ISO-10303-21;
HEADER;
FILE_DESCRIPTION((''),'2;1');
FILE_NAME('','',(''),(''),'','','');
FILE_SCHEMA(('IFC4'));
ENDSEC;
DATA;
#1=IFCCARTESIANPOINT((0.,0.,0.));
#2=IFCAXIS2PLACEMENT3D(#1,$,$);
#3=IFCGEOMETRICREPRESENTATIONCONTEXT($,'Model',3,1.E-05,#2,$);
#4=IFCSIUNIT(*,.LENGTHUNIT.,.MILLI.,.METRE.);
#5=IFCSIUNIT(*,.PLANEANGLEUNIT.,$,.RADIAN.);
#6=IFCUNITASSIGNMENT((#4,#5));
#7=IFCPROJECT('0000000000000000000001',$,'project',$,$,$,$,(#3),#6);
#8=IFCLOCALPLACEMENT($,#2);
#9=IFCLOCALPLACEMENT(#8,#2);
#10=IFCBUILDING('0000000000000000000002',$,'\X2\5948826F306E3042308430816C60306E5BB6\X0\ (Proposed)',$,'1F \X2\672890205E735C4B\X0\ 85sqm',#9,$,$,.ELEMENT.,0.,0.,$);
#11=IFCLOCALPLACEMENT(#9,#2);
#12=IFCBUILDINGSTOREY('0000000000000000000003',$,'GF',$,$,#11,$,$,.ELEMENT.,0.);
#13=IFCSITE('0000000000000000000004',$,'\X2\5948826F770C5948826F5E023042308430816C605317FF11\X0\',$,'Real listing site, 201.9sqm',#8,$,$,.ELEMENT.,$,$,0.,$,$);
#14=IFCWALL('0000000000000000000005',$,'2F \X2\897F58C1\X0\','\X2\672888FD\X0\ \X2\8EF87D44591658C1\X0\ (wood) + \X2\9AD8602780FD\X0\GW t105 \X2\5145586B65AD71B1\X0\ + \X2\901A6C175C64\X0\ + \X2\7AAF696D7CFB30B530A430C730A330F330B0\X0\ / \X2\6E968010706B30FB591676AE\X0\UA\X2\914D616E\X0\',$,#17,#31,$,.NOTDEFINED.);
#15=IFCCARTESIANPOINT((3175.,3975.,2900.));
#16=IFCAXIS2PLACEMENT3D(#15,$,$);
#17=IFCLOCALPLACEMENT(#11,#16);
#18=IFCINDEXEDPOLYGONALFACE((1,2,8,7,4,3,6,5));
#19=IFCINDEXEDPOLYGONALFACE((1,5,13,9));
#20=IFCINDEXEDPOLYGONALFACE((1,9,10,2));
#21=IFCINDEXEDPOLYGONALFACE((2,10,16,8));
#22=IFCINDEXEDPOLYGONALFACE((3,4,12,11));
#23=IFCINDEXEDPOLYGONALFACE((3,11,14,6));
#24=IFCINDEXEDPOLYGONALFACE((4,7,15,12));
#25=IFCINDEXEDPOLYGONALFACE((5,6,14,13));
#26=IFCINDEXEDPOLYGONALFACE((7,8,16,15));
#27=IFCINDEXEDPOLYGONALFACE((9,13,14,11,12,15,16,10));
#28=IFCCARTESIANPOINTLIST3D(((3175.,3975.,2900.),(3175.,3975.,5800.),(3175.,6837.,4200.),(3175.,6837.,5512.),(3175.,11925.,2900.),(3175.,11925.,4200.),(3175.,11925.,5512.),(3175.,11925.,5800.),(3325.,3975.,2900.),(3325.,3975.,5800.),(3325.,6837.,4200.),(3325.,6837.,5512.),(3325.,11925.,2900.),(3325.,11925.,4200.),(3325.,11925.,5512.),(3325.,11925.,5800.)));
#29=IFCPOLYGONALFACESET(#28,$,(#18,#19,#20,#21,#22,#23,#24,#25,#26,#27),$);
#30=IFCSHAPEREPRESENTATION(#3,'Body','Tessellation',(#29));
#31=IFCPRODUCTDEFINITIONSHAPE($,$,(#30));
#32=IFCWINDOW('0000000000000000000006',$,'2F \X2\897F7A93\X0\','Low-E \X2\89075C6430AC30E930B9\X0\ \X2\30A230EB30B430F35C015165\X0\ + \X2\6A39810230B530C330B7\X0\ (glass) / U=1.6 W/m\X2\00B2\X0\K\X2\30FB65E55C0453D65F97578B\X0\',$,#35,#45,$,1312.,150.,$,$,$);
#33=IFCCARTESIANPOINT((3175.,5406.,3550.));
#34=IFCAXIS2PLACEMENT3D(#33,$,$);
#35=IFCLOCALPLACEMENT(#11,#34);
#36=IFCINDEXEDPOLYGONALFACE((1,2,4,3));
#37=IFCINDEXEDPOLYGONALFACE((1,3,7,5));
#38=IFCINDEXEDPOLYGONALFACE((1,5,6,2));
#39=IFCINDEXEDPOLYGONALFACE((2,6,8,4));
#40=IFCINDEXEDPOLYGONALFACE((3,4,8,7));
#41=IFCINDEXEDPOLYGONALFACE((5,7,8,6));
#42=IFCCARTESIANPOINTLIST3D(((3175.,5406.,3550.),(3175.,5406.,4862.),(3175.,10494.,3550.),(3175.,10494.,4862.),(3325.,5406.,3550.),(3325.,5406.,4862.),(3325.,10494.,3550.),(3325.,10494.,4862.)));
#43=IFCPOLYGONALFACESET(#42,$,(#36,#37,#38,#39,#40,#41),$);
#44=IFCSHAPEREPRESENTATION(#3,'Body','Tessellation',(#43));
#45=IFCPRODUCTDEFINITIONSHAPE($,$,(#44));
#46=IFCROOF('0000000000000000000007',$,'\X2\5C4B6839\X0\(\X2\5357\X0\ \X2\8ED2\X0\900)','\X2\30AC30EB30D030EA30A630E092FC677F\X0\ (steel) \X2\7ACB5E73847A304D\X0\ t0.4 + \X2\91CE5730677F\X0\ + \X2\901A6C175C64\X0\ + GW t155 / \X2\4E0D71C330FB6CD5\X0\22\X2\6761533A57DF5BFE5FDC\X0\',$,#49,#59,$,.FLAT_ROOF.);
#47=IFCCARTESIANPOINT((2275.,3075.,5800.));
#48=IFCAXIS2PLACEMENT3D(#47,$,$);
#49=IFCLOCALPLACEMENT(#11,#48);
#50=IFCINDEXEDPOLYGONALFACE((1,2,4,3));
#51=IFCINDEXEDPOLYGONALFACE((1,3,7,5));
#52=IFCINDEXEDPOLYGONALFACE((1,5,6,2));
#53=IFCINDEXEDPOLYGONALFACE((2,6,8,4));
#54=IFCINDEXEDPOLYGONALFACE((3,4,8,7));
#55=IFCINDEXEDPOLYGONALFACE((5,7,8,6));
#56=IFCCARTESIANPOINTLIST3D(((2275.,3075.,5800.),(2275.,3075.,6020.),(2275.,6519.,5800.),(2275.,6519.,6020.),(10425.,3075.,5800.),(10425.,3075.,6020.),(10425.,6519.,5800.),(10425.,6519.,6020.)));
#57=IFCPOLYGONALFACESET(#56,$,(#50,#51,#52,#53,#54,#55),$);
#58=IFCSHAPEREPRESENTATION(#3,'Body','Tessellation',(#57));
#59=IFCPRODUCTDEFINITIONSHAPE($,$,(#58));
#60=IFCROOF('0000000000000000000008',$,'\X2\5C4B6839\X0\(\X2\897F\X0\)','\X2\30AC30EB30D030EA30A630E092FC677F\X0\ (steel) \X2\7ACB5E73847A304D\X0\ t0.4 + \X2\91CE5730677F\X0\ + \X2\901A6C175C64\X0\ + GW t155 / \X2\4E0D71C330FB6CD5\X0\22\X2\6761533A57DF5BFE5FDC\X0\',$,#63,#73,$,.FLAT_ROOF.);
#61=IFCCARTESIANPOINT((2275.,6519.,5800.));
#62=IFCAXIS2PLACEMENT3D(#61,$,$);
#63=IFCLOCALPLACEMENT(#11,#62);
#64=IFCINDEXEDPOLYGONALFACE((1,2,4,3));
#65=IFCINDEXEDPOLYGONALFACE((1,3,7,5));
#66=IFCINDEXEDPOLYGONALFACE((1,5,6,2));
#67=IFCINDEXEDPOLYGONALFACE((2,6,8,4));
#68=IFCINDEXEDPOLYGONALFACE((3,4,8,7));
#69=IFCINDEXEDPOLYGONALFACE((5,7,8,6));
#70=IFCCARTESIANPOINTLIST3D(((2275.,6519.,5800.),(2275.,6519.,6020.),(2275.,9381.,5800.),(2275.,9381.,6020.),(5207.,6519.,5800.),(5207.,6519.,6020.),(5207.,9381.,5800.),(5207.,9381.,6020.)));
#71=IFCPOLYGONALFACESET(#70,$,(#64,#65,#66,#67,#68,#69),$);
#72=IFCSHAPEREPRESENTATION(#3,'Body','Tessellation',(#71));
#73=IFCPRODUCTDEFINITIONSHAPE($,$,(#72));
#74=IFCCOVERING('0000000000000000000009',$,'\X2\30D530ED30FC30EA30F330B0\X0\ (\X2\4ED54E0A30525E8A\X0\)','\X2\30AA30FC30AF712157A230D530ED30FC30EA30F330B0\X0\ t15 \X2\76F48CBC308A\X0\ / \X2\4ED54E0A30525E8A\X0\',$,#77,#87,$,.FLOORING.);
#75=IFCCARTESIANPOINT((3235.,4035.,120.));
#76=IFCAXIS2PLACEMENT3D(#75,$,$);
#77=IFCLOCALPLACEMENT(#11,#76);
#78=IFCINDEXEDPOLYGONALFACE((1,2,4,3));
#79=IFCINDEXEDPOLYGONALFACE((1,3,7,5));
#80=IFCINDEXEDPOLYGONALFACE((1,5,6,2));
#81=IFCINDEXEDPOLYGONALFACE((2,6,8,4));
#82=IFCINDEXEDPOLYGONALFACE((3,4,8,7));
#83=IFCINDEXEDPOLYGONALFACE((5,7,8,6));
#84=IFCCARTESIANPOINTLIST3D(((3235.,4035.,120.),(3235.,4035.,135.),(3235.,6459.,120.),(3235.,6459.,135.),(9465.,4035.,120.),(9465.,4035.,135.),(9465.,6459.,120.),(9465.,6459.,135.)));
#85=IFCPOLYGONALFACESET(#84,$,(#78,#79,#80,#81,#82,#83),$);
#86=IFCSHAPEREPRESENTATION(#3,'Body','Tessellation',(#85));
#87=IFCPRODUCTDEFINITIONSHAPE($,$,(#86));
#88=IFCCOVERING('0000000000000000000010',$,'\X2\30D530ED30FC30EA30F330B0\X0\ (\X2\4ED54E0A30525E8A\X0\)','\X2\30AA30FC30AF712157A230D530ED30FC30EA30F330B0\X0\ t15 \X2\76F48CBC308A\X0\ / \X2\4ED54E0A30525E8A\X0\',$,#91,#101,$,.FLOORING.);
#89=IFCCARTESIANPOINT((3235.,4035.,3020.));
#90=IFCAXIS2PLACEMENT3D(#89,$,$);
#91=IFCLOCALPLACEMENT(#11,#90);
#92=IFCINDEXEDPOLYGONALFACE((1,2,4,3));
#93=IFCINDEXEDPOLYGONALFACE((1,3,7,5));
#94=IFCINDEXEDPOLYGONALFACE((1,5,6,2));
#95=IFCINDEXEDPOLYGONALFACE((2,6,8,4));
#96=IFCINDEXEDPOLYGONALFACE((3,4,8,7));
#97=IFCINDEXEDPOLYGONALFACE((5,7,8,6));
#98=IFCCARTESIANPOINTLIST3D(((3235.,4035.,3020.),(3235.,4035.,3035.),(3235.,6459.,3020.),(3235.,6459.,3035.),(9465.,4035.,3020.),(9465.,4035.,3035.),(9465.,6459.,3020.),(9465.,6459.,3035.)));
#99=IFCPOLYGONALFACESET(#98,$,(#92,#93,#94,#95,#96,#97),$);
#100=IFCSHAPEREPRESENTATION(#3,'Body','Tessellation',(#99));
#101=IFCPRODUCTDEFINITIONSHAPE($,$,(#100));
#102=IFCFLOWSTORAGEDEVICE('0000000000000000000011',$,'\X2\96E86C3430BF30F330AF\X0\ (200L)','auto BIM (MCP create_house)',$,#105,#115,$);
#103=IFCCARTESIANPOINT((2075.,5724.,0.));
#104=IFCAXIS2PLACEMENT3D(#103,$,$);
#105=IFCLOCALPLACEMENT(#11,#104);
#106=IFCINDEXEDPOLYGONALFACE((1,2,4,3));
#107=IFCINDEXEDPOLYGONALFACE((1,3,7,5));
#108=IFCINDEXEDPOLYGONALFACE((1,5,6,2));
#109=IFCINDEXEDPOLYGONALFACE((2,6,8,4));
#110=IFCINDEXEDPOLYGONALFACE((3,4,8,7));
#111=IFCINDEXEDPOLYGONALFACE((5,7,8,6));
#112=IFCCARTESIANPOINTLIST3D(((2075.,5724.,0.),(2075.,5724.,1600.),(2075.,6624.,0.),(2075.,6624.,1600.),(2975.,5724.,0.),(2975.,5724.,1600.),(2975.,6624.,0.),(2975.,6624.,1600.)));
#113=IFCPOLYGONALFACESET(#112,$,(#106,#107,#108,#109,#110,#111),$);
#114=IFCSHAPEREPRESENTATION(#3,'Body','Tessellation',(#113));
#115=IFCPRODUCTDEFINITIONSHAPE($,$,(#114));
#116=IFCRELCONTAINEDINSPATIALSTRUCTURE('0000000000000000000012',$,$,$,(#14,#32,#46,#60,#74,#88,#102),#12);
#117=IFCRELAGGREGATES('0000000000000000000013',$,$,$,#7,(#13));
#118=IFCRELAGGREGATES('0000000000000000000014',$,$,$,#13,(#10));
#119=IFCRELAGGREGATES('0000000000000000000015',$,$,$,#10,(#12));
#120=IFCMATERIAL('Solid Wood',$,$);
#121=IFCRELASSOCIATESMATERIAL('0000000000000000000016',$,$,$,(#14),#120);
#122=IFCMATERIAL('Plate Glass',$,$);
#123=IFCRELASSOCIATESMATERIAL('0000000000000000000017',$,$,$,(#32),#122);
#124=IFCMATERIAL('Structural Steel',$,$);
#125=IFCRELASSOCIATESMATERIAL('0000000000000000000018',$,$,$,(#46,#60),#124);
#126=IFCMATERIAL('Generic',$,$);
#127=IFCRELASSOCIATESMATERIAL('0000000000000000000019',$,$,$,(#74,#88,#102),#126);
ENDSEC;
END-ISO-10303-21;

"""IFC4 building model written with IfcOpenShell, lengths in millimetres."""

from ifc_helpers import new_model, si_unit, frame, frame_2d, origin, place, context, project, spatial, rectangle, extrude, material, element, fill, save


model = new_model("IFC4")

# Units and contexts
model_context = context("Model", 3, precision=1e-05, world=origin())
ifc_project = project(units=[si_unit("LENGTHUNIT", "METRE", prefix="MILLI"), si_unit("PLANEANGLEUNIT", "RADIAN")], contexts=[model_context])

# Site, building, storey
site_placement = place(None, origin())
site = spatial("IfcSite", under=ifc_project, at=site_placement, Name="奈良県奈良市あやめ池北１", ObjectType="Real listing site, 201.9sqm", CompositionType="ELEMENT", RefElevation=0.0)
building_placement = place(site_placement, origin())
building = spatial("IfcBuilding", under=site, at=building_placement, Name="奈良のあやめ池の家 (Proposed)", ObjectType="1F 木造平屋 85sqm", CompositionType="ELEMENT", ElevationOfRefHeight=0.0, ElevationOfTerrain=0.0)
storey_placement = place(building_placement, origin())
storey = spatial("IfcBuildingStorey", under=building, at=storey_placement, Name="GF", CompositionType="ELEMENT", Elevation=0.0)

# Shared definitions
ifc_material_1 = material(Name="Solid Wood")
ifc_material_2 = material(Name="Generic")

# Shared definitions
ifc_material_3 = material(Name="Plate Glass")

# Wall, opening, window
wall_1_placement = place(storey_placement, frame((3175.0, 3975.0, 2900.0)))
wall_1 = element("IfcWall", 1, at=wall_1_placement, inside=storey, material=ifc_material_1, Name="2F 西壁", Description="木製 軸組外壁 (wood) + 高性能GW t105 充填断熱 + 通気層 + 窯業系サイディング / 準耐火・外皮UA配慮", PredefinedType="NOTDEFINED", context=model_context, shape_type="SweptSolid", body=[
    extrude(rectangle(XDim=150.0, YDim=7950.0, at=frame_2d((75.0, 3975.0))), frame((3175.0, 3975.0, 2900.0)), (0.0, 0.0, 1.0), 2900.0),
])
opening_1_placement = place(storey_placement, frame((3175.0, 5406.0, 3550.0)))
opening_1 = element("IfcOpeningElement", 2, at=opening_1_placement, cuts=wall_1, PredefinedType="NOTDEFINED", context=model_context, shape_type="SweptSolid", body=[
    extrude(rectangle(XDim=150.0, YDim=5088.0, at=frame_2d((75.0, 2544.0))), frame((3175.0, 5406.0, 3550.0)), (0.0, 0.0, 1.0), 1312.0),
])
window_1_placement = place(storey_placement, frame((3175.0, 5406.0, 3550.0)))
window_1 = element("IfcWindow", 3, at=window_1_placement, inside=storey, material=ifc_material_3, Name="2F 西窓", Description="Low-E 複層ガラス アルゴン封入 + 樹脂サッシ (glass) / U=1.6 W/m²K・日射取得型", OverallHeight=1312.0, OverallWidth=150.0, context=model_context, shape_type="SweptSolid", body=[
    extrude(rectangle(XDim=150.0, YDim=5088.0, at=frame_2d((75.0, 2544.0))), frame((3175.0, 5406.0, 3550.0)), (0.0, 0.0, 1.0), 1312.0),
])
fill(opening_1, window_1)

# Roofs
ifc_material_4 = material(Name="Structural Steel")
roof_1_placement = place(storey_placement, frame((2275.0, 3075.0, 5800.0)))
element("IfcRoof", 4, at=roof_1_placement, inside=storey, material=ifc_material_4, Name="屋根(南 軒900)", Description="ガルバリウム鋼板 (steel) 立平葺き t0.4 + 野地板 + 通気層 + GW t155 / 不燃・法22条区域対応", PredefinedType="FLAT_ROOF", context=model_context, shape_type="SweptSolid", body=[
    extrude(rectangle(XDim=8150.0, YDim=3444.0, at=frame_2d((4075.0, 1722.0))), frame((2275.0, 3075.0, 5800.0)), (0.0, 0.0, 1.0), 220.0),
])
roof_2_placement = place(storey_placement, frame((2275.0, 6519.0, 5800.0)))
element("IfcRoof", 5, at=roof_2_placement, inside=storey, material=ifc_material_4, Name="屋根(西)", Description="ガルバリウム鋼板 (steel) 立平葺き t0.4 + 野地板 + 通気層 + GW t155 / 不燃・法22条区域対応", PredefinedType="FLAT_ROOF", context=model_context, shape_type="SweptSolid", body=[
    extrude(rectangle(XDim=2932.0, YDim=2862.0, at=frame_2d((1466.0, 1431.0))), frame((2275.0, 6519.0, 5800.0)), (0.0, 0.0, 1.0), 220.0),
])

# Coverings
covering_1_placement = place(storey_placement, frame((3235.0, 4035.0, 120.0)))
element("IfcCovering", 6, at=covering_1_placement, inside=storey, material=ifc_material_2, Name="フローリング (仕上げ床)", Description="オーク無垢フローリング t15 直貼り / 仕上げ床", PredefinedType="FLOORING", context=model_context, shape_type="SweptSolid", body=[
    extrude(rectangle(XDim=6230.0, YDim=2424.0, at=frame_2d((3115.0, 1212.0))), frame((3235.0, 4035.0, 120.0)), (0.0, 0.0, 1.0), 15.0),
])
covering_2_placement = place(storey_placement, frame((3235.0, 4035.0, 3020.0)))
element("IfcCovering", 7, at=covering_2_placement, inside=storey, material=ifc_material_2, Name="フローリング (仕上げ床)", Description="オーク無垢フローリング t15 直貼り / 仕上げ床", PredefinedType="FLOORING", context=model_context, shape_type="SweptSolid", body=[
    extrude(rectangle(XDim=6230.0, YDim=2424.0, at=frame_2d((3115.0, 1212.0))), frame((3235.0, 4035.0, 3020.0)), (0.0, 0.0, 1.0), 15.0),
])

# Flow storage device
flow_storage_device_placement = place(storey_placement, frame((2075.0, 5724.0, 0.0)))
element("IfcFlowStorageDevice", 8, at=flow_storage_device_placement, inside=storey, material=ifc_material_2, Name="雨水タンク (200L)", Description="auto BIM (MCP create_house)", context=model_context, shape_type="SweptSolid", body=[
    extrude(rectangle(XDim=900.0, YDim=900.0, at=frame_2d((450.0, 450.0))), frame((2075.0, 5724.0, 0.0)), (0.0, 0.0, 1.0), 1600.0),
])

save(model, "model.ifc")
